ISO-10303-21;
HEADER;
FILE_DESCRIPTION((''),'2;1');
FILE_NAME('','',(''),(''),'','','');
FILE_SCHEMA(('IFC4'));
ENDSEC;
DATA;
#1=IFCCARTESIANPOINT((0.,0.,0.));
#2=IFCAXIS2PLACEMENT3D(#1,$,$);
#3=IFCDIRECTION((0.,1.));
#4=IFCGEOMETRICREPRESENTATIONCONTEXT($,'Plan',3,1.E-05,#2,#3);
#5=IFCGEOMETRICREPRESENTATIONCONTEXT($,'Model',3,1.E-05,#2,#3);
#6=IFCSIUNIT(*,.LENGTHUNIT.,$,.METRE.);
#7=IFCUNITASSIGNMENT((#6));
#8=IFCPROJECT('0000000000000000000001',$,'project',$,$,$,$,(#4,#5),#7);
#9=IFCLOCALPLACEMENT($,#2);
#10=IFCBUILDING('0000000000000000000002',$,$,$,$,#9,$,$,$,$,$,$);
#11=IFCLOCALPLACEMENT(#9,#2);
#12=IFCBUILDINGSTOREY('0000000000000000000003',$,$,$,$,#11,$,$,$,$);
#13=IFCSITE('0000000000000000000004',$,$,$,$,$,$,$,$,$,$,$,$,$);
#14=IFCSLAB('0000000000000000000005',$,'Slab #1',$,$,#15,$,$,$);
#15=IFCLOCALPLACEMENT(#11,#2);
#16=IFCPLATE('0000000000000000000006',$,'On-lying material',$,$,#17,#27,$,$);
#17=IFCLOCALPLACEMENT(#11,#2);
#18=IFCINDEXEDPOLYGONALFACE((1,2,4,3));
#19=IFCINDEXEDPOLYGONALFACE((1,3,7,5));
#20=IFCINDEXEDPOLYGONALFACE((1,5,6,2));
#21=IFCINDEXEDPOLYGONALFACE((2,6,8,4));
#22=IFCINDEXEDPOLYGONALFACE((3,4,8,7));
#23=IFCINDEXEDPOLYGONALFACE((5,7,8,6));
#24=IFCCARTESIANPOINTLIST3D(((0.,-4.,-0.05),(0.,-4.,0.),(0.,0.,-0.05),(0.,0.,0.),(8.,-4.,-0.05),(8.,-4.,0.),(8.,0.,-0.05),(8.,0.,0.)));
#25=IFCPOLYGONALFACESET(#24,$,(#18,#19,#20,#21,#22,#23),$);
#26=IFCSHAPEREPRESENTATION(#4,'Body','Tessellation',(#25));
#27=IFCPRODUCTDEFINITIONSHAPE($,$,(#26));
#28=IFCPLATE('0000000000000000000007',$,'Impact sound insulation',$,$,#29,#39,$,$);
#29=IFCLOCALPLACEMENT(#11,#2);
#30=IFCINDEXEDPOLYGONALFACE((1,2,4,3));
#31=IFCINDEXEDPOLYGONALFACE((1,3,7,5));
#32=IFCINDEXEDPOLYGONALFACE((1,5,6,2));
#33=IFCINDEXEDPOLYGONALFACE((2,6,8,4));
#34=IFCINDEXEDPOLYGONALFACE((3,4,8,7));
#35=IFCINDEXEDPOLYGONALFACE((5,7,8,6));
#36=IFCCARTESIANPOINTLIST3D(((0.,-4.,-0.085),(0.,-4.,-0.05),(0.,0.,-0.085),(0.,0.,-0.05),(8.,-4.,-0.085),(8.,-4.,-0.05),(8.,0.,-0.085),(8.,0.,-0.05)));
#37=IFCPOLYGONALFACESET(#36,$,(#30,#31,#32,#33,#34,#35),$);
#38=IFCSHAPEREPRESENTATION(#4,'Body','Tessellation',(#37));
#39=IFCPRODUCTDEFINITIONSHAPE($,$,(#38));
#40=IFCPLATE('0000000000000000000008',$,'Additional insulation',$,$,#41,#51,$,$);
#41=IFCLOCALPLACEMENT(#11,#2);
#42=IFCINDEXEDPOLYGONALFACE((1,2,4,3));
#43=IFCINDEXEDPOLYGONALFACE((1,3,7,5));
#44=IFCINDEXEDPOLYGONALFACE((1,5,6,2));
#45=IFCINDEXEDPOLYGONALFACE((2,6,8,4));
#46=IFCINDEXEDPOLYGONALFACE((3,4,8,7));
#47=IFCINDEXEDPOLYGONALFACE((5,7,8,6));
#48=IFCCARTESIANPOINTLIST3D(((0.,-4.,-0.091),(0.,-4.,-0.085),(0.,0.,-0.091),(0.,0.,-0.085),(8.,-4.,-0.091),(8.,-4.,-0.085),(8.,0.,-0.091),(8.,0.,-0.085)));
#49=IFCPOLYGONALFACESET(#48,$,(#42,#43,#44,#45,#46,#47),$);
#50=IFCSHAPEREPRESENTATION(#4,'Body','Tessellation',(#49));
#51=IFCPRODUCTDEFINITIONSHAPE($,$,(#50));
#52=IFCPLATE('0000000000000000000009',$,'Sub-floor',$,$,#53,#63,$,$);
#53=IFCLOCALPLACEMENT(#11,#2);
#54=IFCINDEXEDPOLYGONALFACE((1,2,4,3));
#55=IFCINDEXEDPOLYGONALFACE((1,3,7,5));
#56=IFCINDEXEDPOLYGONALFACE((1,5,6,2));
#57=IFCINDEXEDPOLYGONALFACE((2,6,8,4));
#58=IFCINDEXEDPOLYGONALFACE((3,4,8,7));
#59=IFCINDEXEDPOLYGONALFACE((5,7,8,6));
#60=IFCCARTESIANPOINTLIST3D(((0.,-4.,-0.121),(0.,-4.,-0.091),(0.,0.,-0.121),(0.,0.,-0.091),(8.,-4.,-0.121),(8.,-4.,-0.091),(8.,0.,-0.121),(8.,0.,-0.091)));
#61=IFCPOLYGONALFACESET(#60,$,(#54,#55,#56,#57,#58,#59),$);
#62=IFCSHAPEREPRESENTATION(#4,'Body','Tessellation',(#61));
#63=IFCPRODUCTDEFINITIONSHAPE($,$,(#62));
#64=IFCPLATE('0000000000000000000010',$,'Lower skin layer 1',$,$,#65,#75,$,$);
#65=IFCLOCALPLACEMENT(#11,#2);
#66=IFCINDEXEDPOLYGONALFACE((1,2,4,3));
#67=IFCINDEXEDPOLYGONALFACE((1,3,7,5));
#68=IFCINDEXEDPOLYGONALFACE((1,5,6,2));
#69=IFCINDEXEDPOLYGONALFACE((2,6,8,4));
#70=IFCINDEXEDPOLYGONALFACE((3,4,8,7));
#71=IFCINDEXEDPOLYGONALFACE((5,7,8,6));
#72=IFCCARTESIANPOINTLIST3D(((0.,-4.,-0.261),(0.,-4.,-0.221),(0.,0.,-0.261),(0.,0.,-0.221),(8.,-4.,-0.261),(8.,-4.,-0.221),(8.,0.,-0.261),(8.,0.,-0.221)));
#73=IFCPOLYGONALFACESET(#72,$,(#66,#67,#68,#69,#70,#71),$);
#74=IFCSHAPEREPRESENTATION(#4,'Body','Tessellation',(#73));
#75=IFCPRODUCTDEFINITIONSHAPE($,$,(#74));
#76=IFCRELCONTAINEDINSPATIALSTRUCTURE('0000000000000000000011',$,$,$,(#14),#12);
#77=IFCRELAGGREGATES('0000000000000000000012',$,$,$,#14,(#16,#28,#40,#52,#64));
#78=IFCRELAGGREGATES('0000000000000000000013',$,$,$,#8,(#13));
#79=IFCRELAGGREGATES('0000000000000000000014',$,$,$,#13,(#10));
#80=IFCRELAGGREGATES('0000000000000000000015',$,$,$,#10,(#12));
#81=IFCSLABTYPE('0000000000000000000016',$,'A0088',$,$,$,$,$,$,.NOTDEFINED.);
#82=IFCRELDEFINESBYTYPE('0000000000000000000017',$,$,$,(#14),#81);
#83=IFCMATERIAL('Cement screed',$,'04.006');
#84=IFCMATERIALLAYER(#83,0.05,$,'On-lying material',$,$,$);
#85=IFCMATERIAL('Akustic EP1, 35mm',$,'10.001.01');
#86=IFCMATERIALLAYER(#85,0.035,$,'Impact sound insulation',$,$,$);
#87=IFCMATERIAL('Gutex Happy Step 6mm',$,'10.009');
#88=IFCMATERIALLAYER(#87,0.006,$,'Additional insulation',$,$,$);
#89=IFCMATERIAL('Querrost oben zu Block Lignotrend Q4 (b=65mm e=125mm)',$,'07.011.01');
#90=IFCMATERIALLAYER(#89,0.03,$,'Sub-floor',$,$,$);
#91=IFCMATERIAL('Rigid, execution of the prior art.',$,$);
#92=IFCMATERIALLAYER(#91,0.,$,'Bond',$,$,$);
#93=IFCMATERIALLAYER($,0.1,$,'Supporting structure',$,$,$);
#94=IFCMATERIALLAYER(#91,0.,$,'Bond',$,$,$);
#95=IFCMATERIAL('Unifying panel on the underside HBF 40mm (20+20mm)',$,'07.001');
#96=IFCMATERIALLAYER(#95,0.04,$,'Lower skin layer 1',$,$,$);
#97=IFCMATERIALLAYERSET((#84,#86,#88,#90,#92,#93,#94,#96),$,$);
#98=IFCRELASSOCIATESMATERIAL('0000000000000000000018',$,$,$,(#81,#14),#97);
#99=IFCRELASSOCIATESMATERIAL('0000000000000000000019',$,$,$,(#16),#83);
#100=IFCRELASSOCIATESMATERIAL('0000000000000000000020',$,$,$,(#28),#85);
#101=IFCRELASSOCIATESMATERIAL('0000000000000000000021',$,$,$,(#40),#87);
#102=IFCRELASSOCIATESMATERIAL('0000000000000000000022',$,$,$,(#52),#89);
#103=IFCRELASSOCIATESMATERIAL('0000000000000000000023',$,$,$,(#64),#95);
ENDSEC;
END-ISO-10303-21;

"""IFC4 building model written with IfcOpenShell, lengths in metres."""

from ifc_helpers import new_model, si_unit, direction, frame, frame_2d, origin, origin_with_axes, place, context, project, spatial, rectangle, extrude, material, layer, layer_set, type_object, element, aggregate, save


model = new_model("IFC4")

# Units and contexts
plan_context = context("Plan", 3, precision=1e-05, world=origin(), true_north=direction((0.0, 1.0)))
model_context = context("Model", 3, precision=1e-05, world=origin(), true_north=direction((0.0, 1.0)))
ifc_project = project(units=[si_unit("LENGTHUNIT", "METRE")], contexts=[plan_context, model_context])

# Site, building, storey
site = spatial("IfcSite", under=ifc_project)
building_placement = place(None, origin())
building = spatial("IfcBuilding", under=site, at=building_placement)
storey_placement = place(building_placement, origin())
storey = spatial("IfcBuildingStorey", under=building, at=storey_placement)

# Slab, plates
ifc_material_1 = material(Name="Cement screed", Category="04.006")
ifc_layer_1 = layer(ifc_material_1, 0.05, Name="On-lying material")
ifc_material_2 = material(Name="Akustic EP1, 35mm", Category="10.001.01")
ifc_layer_2 = layer(ifc_material_2, 0.035, Name="Impact sound insulation")
ifc_material_3 = material(Name="Gutex Happy Step 6mm", Category="10.009")
ifc_layer_3 = layer(ifc_material_3, 0.006, Name="Additional insulation")
ifc_material_4 = material(Name="Querrost oben zu Block Lignotrend Q4 (b=65mm e=125mm)", Category="07.011.01")
ifc_layer_4 = layer(ifc_material_4, 0.03, Name="Sub-floor")
ifc_material_5 = material(Name="Rigid, execution of the prior art.")
ifc_layer_5 = layer(ifc_material_5, 0.0, Name="Bond")
ifc_layer_6 = layer(None, 0.1, Name="Supporting structure")
ifc_layer_7 = layer(ifc_material_5, 0.0, Name="Bond")
ifc_material_6 = material(Name="Unifying panel on the underside HBF 40mm (20+20mm)", Category="07.001")
ifc_layer_8 = layer(ifc_material_6, 0.04, Name="Lower skin layer 1")
ifc_layer_set = layer_set([ifc_layer_1, ifc_layer_2, ifc_layer_3, ifc_layer_4, ifc_layer_5, ifc_layer_6, ifc_layer_7, ifc_layer_8])
slab_type = type_object("IfcSlabType", Name="A0088", PredefinedType="NOTDEFINED", material=ifc_layer_set)
slab_placement = place(None, frame((0.0, 0.0, 0.0), z_axis=(0.0, 0.0, -1.0), x_axis=(1.0, 0.0, 0.0)))
slab = element("IfcSlab", 1, at=slab_placement, inside=storey, type_object=slab_type, material=ifc_layer_set, Name="Slab #1")
plate_1_placement = place(slab_placement, origin())
plate_1 = element("IfcPlate", 2, at=plate_1_placement, material=ifc_material_1, Name="On-lying material", context=plan_context, shape_type="SweptSolid", body=[
    extrude(rectangle(XDim=8.0, YDim=4.0, at=frame_2d((4.0, 2.0), x_axis=(1.0, 0.0))), origin_with_axes(), (0.0, 0.0, 1.0), 0.05),
])
plate_2_placement = place(slab_placement, origin())
plate_2 = element("IfcPlate", 3, at=plate_2_placement, material=ifc_material_2, Name="Impact sound insulation", context=plan_context, shape_type="SweptSolid", body=[
    extrude(rectangle(XDim=8.0, YDim=4.0, at=frame_2d((4.0, 2.0), x_axis=(1.0, 0.0))), frame((0.0, 0.0, 0.05), z_axis=(0.0, 0.0, 1.0), x_axis=(1.0, 0.0, 0.0)), (0.0, 0.0, 1.0), 0.035),
])
plate_3_placement = place(slab_placement, origin())
plate_3 = element("IfcPlate", 4, at=plate_3_placement, material=ifc_material_3, Name="Additional insulation", context=plan_context, shape_type="SweptSolid", body=[
    extrude(rectangle(XDim=8.0, YDim=4.0, at=frame_2d((4.0, 2.0), x_axis=(1.0, 0.0))), frame((0.0, 0.0, 0.085), z_axis=(0.0, 0.0, 1.0), x_axis=(1.0, 0.0, 0.0)), (0.0, 0.0, 1.0), 0.006),
])
plate_4_placement = place(slab_placement, origin())
plate_4 = element("IfcPlate", 5, at=plate_4_placement, material=ifc_material_4, Name="Sub-floor", context=plan_context, shape_type="SweptSolid", body=[
    extrude(rectangle(XDim=8.0, YDim=4.0, at=frame_2d((4.0, 2.0), x_axis=(1.0, 0.0))), frame((0.0, 0.0, 0.091), z_axis=(0.0, 0.0, 1.0), x_axis=(1.0, 0.0, 0.0)), (0.0, 0.0, 1.0), 0.03),
])
plate_5_placement = place(slab_placement, origin())
plate_5 = element("IfcPlate", 6, at=plate_5_placement, material=ifc_material_6, Name="Lower skin layer 1", context=plan_context, shape_type="SweptSolid", body=[
    extrude(rectangle(XDim=8.0, YDim=4.0, at=frame_2d((4.0, 2.0), x_axis=(1.0, 0.0))), frame((0.0, 0.0, 0.221), z_axis=(0.0, 0.0, 1.0), x_axis=(1.0, 0.0, 0.0)), (0.0, 0.0, 1.0), 0.04),
])
aggregate(slab, [plate_1, plate_2, plate_3, plate_4, plate_5])

save(model, "model.ifc")
